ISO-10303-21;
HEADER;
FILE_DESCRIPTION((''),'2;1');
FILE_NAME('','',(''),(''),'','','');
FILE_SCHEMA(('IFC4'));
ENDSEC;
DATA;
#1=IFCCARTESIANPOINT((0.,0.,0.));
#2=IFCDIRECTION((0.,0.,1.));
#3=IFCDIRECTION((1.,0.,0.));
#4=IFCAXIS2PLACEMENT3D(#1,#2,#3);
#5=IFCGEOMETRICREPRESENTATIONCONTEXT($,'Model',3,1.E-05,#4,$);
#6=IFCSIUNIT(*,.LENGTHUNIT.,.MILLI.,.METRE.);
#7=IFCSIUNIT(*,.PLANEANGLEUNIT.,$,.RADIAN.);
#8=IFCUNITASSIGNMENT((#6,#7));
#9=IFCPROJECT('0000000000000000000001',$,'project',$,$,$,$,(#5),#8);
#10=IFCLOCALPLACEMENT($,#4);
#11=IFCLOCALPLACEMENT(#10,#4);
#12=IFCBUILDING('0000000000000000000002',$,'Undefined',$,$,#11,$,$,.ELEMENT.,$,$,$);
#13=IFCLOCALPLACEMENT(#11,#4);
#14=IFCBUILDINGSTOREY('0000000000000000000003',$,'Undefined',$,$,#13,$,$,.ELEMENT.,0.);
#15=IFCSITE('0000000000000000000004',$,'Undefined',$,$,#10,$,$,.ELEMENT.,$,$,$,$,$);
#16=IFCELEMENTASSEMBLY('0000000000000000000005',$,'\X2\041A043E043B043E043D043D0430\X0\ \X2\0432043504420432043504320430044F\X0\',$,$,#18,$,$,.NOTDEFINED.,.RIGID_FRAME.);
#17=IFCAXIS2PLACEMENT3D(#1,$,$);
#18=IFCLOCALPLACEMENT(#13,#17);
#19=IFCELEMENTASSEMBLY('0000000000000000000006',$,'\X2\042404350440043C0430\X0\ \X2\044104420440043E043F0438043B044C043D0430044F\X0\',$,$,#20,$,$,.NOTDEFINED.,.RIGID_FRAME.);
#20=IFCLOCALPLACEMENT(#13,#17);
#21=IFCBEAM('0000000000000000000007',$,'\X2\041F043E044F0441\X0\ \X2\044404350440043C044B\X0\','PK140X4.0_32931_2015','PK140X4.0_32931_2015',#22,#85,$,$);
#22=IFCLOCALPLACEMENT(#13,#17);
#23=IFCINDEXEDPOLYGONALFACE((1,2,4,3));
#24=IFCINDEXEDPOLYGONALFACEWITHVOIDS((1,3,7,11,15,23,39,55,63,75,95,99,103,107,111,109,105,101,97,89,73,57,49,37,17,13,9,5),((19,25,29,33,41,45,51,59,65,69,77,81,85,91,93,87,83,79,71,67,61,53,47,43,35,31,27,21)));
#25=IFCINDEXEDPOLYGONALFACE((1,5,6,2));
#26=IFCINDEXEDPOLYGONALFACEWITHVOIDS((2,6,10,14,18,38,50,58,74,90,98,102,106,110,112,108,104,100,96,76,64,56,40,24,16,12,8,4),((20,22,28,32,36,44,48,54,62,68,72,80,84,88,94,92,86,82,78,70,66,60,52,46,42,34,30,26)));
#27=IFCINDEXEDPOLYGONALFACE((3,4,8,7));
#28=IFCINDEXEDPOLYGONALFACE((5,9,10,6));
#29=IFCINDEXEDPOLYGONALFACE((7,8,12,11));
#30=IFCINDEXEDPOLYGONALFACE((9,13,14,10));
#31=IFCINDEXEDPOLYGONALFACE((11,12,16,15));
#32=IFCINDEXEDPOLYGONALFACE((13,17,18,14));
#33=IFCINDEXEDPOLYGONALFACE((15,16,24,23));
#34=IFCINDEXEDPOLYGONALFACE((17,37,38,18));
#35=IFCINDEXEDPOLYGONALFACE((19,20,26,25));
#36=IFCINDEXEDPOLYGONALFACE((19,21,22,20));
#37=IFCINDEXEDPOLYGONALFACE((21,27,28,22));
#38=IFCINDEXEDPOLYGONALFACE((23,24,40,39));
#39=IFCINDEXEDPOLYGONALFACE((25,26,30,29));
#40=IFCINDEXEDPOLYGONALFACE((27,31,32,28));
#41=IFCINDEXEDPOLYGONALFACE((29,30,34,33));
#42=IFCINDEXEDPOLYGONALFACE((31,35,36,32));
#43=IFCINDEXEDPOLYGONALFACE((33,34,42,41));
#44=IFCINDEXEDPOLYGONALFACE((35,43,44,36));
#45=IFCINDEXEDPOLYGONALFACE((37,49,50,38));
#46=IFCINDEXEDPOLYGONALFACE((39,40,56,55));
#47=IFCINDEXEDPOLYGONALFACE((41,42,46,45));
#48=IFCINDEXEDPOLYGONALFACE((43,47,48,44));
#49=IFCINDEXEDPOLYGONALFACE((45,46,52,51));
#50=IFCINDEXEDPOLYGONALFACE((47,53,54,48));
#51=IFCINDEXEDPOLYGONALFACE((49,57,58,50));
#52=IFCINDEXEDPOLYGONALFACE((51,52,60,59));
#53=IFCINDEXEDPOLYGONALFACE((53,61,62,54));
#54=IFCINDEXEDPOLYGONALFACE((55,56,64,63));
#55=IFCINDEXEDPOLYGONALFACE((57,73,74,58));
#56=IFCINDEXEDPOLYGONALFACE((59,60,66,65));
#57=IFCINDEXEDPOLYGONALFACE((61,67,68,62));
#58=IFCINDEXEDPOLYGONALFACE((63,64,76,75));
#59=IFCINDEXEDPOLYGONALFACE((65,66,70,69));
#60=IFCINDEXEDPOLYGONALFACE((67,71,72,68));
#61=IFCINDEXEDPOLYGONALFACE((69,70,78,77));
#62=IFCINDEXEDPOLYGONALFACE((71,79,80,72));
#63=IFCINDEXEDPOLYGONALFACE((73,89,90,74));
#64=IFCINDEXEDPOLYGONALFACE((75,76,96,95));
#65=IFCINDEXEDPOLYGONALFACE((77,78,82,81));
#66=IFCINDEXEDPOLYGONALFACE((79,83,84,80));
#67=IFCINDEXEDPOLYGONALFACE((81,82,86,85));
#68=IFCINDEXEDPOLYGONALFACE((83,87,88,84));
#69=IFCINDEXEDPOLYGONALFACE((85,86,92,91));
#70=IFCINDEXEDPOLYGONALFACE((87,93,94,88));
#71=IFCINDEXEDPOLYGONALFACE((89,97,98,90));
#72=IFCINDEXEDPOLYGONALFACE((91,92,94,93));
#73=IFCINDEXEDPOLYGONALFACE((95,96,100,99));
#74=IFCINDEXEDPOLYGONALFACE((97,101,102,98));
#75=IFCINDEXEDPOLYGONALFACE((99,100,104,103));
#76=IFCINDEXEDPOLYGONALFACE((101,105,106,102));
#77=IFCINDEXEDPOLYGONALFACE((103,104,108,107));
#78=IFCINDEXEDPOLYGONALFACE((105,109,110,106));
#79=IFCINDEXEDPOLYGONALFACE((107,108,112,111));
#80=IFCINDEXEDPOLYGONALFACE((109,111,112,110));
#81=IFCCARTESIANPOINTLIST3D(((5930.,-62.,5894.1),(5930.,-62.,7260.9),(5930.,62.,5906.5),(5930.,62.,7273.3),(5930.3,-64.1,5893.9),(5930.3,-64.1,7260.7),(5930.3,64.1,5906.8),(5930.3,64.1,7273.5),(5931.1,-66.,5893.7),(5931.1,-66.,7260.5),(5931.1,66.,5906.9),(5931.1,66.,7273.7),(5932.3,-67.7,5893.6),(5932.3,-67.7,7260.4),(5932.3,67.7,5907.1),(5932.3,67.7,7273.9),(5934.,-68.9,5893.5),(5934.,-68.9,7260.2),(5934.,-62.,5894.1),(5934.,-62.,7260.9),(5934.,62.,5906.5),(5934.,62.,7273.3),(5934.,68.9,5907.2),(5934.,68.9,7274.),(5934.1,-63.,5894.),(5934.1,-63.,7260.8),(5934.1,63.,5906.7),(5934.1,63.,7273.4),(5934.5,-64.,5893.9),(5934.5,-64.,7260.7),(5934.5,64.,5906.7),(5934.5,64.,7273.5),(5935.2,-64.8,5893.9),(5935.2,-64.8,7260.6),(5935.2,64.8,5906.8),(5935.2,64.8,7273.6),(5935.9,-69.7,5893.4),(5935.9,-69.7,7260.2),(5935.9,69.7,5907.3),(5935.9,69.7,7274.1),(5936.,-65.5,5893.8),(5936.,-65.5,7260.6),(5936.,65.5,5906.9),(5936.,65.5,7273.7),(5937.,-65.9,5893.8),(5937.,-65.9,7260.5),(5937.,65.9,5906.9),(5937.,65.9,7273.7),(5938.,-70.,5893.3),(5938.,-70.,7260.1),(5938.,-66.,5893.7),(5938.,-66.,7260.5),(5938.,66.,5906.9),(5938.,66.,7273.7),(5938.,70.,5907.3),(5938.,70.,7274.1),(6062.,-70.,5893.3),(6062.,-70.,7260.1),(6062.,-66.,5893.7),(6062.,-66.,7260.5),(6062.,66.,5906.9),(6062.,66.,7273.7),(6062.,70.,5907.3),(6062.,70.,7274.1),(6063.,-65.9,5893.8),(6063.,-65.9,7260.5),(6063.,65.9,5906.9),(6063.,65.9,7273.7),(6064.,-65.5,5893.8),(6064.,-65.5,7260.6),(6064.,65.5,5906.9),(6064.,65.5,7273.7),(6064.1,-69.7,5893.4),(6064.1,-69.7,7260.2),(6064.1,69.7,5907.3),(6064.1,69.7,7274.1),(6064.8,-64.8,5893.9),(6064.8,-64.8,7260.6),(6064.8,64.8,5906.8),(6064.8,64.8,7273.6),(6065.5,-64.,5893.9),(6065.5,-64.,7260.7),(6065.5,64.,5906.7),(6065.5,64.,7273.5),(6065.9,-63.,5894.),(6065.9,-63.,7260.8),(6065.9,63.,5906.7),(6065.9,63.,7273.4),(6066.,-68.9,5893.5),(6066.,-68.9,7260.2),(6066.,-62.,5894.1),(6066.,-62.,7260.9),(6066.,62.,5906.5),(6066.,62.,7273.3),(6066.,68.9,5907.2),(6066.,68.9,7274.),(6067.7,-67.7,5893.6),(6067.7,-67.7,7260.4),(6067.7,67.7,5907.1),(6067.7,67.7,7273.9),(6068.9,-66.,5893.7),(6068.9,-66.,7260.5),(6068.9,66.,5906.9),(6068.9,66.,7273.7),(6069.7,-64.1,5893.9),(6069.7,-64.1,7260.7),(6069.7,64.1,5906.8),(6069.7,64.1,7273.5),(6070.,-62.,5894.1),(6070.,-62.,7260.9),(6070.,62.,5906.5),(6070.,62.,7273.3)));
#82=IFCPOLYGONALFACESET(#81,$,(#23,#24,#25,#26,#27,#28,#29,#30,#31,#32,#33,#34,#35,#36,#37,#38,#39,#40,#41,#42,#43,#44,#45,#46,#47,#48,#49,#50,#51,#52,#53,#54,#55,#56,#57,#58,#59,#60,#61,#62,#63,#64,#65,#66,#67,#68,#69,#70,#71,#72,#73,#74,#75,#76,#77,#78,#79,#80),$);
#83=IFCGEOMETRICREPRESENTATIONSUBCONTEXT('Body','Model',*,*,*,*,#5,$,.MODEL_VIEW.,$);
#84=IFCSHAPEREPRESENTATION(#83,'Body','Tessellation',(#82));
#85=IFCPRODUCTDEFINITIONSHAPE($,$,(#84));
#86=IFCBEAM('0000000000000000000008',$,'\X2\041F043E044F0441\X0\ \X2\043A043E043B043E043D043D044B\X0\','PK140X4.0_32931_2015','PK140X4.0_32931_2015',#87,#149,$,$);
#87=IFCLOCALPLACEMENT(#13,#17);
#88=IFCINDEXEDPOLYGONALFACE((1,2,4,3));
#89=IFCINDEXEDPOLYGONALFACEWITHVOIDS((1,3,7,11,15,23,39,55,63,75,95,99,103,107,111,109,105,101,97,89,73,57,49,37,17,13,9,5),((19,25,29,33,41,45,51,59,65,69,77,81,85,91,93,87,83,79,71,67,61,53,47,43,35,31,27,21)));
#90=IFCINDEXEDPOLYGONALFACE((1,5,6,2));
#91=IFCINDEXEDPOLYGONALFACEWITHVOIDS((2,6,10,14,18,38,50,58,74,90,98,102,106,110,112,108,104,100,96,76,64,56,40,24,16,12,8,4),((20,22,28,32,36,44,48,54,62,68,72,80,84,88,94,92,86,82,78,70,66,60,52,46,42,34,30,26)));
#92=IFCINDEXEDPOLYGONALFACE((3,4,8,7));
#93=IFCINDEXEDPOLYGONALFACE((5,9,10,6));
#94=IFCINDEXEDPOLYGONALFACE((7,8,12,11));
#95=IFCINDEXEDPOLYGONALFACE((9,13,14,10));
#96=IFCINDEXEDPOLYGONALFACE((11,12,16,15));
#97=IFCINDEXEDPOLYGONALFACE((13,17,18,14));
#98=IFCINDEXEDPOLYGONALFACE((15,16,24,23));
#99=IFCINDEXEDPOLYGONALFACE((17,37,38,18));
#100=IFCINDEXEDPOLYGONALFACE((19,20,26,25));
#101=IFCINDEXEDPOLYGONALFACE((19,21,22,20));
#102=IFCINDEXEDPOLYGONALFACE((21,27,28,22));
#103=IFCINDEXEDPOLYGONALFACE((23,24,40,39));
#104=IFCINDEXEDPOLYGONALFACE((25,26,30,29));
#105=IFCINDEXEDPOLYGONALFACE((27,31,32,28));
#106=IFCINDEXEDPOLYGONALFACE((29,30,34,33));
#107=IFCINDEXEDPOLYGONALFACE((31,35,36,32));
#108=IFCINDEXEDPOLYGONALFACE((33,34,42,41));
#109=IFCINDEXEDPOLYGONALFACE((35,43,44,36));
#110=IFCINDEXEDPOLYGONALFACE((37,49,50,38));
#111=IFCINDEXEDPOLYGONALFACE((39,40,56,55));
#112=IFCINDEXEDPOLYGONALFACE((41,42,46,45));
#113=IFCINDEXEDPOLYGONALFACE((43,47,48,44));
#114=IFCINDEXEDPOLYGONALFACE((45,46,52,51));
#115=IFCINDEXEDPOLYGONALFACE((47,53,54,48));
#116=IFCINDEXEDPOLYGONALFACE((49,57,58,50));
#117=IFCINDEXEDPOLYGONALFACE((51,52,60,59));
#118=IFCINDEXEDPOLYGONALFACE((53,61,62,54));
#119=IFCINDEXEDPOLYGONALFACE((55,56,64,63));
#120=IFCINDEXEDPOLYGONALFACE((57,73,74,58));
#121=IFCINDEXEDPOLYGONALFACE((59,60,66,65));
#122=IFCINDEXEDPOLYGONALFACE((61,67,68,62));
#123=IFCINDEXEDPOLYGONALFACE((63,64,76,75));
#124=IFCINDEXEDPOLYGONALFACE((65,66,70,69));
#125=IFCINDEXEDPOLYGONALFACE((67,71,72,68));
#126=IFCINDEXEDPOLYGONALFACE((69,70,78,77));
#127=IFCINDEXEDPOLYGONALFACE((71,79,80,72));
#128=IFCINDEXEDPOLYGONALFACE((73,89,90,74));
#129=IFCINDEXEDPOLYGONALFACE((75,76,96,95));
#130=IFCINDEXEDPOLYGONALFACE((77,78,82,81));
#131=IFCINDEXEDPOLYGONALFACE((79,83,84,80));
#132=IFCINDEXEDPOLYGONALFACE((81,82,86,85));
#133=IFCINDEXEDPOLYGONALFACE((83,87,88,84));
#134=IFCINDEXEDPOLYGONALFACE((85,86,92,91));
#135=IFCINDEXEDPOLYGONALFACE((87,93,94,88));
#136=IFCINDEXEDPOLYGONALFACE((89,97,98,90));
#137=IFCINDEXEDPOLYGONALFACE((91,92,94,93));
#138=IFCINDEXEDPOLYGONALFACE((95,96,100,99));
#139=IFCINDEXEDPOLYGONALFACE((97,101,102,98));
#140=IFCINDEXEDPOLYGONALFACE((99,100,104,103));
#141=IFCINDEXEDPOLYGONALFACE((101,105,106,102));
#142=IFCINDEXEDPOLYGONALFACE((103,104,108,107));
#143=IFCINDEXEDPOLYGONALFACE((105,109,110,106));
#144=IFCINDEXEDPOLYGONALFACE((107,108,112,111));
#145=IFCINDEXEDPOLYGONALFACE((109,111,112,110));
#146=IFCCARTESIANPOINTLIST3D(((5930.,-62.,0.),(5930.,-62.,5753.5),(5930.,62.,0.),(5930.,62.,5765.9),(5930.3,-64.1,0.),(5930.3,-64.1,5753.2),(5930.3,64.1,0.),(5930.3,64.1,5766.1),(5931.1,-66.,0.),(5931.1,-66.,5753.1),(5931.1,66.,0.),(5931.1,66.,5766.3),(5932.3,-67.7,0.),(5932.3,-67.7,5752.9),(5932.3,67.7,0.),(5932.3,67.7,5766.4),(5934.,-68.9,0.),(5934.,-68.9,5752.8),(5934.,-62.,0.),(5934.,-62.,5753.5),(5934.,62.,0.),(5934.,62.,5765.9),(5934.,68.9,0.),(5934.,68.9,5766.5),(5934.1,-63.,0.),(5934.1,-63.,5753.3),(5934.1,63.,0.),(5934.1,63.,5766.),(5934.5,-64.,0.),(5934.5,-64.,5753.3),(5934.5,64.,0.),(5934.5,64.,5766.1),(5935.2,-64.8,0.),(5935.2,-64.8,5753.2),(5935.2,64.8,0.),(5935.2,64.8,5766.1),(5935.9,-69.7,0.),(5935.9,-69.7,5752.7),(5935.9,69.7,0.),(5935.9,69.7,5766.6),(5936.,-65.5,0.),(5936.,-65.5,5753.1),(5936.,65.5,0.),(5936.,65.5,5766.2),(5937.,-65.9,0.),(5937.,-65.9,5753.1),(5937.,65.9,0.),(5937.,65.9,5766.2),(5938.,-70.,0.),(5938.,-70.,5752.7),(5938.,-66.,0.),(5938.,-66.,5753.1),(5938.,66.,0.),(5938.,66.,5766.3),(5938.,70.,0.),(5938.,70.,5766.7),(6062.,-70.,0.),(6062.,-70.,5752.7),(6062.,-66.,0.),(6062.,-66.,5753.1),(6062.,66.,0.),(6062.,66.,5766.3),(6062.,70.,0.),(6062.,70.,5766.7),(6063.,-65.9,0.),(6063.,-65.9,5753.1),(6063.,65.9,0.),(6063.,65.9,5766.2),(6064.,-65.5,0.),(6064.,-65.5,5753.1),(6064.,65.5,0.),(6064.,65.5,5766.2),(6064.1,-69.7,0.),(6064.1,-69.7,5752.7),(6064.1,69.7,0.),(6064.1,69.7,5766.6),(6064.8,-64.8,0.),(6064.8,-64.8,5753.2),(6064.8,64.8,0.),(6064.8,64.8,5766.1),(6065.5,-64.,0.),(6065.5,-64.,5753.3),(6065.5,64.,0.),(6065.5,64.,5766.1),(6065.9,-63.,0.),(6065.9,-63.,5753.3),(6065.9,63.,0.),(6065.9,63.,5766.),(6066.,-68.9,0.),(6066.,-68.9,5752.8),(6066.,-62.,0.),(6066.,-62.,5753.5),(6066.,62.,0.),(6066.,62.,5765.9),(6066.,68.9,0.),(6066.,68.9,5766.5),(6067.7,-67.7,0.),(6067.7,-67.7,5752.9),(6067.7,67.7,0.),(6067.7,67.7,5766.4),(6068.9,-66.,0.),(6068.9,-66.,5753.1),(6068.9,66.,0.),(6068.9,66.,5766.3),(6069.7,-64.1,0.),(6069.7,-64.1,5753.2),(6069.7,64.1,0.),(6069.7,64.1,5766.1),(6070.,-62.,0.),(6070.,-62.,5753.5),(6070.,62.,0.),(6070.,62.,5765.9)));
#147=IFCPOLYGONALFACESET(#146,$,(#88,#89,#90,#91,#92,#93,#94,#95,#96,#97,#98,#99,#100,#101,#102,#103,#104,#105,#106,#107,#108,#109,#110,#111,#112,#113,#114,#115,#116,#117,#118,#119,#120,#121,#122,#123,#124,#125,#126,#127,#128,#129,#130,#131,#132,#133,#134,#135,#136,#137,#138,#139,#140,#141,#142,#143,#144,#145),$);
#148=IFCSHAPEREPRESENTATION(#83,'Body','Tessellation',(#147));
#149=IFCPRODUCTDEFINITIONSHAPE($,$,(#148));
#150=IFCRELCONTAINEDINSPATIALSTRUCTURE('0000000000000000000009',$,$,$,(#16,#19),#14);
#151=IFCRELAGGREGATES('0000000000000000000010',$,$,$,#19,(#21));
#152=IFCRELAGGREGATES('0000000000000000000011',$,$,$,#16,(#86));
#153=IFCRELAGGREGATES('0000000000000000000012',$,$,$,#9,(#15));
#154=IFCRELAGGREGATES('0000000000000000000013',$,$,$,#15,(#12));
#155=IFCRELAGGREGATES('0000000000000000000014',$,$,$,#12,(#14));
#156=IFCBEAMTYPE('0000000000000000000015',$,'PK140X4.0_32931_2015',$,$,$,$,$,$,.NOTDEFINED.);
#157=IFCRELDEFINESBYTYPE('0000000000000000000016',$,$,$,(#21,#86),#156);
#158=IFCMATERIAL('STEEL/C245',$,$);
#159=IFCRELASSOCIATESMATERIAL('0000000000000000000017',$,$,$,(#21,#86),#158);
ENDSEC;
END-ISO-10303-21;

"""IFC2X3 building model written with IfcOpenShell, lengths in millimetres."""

from ifc_helpers import new_model, si_unit, frame, origin_with_axes, origin_2d_with_axis, place, context, subcontext, project, spatial, hollow_rectangle, extrude, clip, halfspace, material, type_object, element, aggregate, save


model = new_model("IFC2X3")

# Units and contexts
model_context = context("Model", 3, precision=1e-05, world=origin_with_axes())
body_context = subcontext(model_context, "Body", "Model", "MODEL_VIEW")
ifc_project = project(units=[si_unit("LENGTHUNIT", "METRE", prefix="MILLI"), si_unit("PLANEANGLEUNIT", "RADIAN")], contexts=[model_context])

# Site, building, storey
site_placement = place(None, origin_with_axes())
site = spatial("IfcSite", under=ifc_project, at=site_placement, Name="Undefined", CompositionType="ELEMENT")
building_placement = place(site_placement, origin_with_axes())
building = spatial("IfcBuilding", under=site, at=building_placement, Name="Undefined", CompositionType="ELEMENT")
storey_placement = place(building_placement, origin_with_axes())
storey = spatial("IfcBuildingStorey", under=building, at=storey_placement, Name="Undefined", CompositionType="ELEMENT", Elevation=0.0)

# Shared definitions
ifc_material_1 = material(Name="STEEL/C245")

# Element assembly
assembly_1_placement = place(storey_placement, origin_with_axes())
assembly_1 = element("IfcElementAssembly", 1, at=assembly_1_placement, inside=storey, Name="Колонна ветвевая", AssemblyPlace="NOTDEFINED", PredefinedType="RIGID_FRAME")

# Element assembly, beam
assembly_2_placement = place(storey_placement, origin_with_axes())
assembly_2 = element("IfcElementAssembly", 2, at=assembly_2_placement, inside=storey, Name="Ферма стропильная", AssemblyPlace="NOTDEFINED", PredefinedType="RIGID_FRAME")
beam_type_1 = type_object("IfcBeamType", Name="PK140X4.0_32931_2015", PredefinedType="NOTDEFINED")
beam_1_placement = place(assembly_2_placement, frame((6000.0, 0.0, 7260.1), z_axis=(1.0, 0.0, 0.0), x_axis=(0.0, 0.0, -1.0)))
beam_1 = element("IfcBeam", 3, at=beam_1_placement, type_object=beam_type_1, material=ifc_material_1, Name="Пояс фермы", Description="PK140X4.0_32931_2015", ObjectType="PK140X4.0_32931_2015", context=body_context, shape_type="Clipping", body=[
    clip(clip(extrude(hollow_rectangle(XDim=140.0, YDim=140.0, WallThickness=4.0, InnerFilletRadius=4.0, OuterFilletRadius=8.0, at=origin_2d_with_axis()), frame((1373.9, 0.0, 0.0), z_axis=(-1.0, 0.0, 0.0), x_axis=(0.0, -1.0, 0.0)), (0.0, 0.0, 1.0), 1395.1), halfspace(frame((1348.5, 112.4, 0.0), z_axis=(0.995037, 0.099504, 0.0), x_axis=(0.0, 0.0, 1.0)), False)), halfspace(frame((-20.7, 136.7, 0.0), z_axis=(0.995037, 0.099504, 0.0), x_axis=(0.0, 0.0, 1.0)), True)),
])

# Beam
beam_2_placement = place(assembly_1_placement, frame((6000.0, 0.0, 6000.0), z_axis=(1.0, 0.0, 0.0), x_axis=(0.0, 0.0, -1.0)))
beam_2 = element("IfcBeam", 4, at=beam_2_placement, type_object=beam_type_1, material=ifc_material_1, Name="Пояс колонны", Description="PK140X4.0_32931_2015", ObjectType="PK140X4.0_32931_2015", context=body_context, shape_type="Clipping", body=[
    clip(extrude(hollow_rectangle(XDim=140.0, YDim=140.0, WallThickness=4.0, InnerFilletRadius=4.0, OuterFilletRadius=8.0, at=origin_2d_with_axis()), frame((6000.0, 0.0, 0.0), z_axis=(-1.0, 0.0, 0.0), x_axis=(0.0, -1.0, 0.0)), (0.0, 0.0, 1.0), 5766.7), halfspace(frame((232.4, 79.1, 0.0), z_axis=(0.995037, 0.099504, 0.0), x_axis=(0.0, 0.0, 1.0)), True)),
])
aggregate(assembly_2, [beam_1])

aggregate(assembly_1, [beam_2])

save(model, "model.ifc")
